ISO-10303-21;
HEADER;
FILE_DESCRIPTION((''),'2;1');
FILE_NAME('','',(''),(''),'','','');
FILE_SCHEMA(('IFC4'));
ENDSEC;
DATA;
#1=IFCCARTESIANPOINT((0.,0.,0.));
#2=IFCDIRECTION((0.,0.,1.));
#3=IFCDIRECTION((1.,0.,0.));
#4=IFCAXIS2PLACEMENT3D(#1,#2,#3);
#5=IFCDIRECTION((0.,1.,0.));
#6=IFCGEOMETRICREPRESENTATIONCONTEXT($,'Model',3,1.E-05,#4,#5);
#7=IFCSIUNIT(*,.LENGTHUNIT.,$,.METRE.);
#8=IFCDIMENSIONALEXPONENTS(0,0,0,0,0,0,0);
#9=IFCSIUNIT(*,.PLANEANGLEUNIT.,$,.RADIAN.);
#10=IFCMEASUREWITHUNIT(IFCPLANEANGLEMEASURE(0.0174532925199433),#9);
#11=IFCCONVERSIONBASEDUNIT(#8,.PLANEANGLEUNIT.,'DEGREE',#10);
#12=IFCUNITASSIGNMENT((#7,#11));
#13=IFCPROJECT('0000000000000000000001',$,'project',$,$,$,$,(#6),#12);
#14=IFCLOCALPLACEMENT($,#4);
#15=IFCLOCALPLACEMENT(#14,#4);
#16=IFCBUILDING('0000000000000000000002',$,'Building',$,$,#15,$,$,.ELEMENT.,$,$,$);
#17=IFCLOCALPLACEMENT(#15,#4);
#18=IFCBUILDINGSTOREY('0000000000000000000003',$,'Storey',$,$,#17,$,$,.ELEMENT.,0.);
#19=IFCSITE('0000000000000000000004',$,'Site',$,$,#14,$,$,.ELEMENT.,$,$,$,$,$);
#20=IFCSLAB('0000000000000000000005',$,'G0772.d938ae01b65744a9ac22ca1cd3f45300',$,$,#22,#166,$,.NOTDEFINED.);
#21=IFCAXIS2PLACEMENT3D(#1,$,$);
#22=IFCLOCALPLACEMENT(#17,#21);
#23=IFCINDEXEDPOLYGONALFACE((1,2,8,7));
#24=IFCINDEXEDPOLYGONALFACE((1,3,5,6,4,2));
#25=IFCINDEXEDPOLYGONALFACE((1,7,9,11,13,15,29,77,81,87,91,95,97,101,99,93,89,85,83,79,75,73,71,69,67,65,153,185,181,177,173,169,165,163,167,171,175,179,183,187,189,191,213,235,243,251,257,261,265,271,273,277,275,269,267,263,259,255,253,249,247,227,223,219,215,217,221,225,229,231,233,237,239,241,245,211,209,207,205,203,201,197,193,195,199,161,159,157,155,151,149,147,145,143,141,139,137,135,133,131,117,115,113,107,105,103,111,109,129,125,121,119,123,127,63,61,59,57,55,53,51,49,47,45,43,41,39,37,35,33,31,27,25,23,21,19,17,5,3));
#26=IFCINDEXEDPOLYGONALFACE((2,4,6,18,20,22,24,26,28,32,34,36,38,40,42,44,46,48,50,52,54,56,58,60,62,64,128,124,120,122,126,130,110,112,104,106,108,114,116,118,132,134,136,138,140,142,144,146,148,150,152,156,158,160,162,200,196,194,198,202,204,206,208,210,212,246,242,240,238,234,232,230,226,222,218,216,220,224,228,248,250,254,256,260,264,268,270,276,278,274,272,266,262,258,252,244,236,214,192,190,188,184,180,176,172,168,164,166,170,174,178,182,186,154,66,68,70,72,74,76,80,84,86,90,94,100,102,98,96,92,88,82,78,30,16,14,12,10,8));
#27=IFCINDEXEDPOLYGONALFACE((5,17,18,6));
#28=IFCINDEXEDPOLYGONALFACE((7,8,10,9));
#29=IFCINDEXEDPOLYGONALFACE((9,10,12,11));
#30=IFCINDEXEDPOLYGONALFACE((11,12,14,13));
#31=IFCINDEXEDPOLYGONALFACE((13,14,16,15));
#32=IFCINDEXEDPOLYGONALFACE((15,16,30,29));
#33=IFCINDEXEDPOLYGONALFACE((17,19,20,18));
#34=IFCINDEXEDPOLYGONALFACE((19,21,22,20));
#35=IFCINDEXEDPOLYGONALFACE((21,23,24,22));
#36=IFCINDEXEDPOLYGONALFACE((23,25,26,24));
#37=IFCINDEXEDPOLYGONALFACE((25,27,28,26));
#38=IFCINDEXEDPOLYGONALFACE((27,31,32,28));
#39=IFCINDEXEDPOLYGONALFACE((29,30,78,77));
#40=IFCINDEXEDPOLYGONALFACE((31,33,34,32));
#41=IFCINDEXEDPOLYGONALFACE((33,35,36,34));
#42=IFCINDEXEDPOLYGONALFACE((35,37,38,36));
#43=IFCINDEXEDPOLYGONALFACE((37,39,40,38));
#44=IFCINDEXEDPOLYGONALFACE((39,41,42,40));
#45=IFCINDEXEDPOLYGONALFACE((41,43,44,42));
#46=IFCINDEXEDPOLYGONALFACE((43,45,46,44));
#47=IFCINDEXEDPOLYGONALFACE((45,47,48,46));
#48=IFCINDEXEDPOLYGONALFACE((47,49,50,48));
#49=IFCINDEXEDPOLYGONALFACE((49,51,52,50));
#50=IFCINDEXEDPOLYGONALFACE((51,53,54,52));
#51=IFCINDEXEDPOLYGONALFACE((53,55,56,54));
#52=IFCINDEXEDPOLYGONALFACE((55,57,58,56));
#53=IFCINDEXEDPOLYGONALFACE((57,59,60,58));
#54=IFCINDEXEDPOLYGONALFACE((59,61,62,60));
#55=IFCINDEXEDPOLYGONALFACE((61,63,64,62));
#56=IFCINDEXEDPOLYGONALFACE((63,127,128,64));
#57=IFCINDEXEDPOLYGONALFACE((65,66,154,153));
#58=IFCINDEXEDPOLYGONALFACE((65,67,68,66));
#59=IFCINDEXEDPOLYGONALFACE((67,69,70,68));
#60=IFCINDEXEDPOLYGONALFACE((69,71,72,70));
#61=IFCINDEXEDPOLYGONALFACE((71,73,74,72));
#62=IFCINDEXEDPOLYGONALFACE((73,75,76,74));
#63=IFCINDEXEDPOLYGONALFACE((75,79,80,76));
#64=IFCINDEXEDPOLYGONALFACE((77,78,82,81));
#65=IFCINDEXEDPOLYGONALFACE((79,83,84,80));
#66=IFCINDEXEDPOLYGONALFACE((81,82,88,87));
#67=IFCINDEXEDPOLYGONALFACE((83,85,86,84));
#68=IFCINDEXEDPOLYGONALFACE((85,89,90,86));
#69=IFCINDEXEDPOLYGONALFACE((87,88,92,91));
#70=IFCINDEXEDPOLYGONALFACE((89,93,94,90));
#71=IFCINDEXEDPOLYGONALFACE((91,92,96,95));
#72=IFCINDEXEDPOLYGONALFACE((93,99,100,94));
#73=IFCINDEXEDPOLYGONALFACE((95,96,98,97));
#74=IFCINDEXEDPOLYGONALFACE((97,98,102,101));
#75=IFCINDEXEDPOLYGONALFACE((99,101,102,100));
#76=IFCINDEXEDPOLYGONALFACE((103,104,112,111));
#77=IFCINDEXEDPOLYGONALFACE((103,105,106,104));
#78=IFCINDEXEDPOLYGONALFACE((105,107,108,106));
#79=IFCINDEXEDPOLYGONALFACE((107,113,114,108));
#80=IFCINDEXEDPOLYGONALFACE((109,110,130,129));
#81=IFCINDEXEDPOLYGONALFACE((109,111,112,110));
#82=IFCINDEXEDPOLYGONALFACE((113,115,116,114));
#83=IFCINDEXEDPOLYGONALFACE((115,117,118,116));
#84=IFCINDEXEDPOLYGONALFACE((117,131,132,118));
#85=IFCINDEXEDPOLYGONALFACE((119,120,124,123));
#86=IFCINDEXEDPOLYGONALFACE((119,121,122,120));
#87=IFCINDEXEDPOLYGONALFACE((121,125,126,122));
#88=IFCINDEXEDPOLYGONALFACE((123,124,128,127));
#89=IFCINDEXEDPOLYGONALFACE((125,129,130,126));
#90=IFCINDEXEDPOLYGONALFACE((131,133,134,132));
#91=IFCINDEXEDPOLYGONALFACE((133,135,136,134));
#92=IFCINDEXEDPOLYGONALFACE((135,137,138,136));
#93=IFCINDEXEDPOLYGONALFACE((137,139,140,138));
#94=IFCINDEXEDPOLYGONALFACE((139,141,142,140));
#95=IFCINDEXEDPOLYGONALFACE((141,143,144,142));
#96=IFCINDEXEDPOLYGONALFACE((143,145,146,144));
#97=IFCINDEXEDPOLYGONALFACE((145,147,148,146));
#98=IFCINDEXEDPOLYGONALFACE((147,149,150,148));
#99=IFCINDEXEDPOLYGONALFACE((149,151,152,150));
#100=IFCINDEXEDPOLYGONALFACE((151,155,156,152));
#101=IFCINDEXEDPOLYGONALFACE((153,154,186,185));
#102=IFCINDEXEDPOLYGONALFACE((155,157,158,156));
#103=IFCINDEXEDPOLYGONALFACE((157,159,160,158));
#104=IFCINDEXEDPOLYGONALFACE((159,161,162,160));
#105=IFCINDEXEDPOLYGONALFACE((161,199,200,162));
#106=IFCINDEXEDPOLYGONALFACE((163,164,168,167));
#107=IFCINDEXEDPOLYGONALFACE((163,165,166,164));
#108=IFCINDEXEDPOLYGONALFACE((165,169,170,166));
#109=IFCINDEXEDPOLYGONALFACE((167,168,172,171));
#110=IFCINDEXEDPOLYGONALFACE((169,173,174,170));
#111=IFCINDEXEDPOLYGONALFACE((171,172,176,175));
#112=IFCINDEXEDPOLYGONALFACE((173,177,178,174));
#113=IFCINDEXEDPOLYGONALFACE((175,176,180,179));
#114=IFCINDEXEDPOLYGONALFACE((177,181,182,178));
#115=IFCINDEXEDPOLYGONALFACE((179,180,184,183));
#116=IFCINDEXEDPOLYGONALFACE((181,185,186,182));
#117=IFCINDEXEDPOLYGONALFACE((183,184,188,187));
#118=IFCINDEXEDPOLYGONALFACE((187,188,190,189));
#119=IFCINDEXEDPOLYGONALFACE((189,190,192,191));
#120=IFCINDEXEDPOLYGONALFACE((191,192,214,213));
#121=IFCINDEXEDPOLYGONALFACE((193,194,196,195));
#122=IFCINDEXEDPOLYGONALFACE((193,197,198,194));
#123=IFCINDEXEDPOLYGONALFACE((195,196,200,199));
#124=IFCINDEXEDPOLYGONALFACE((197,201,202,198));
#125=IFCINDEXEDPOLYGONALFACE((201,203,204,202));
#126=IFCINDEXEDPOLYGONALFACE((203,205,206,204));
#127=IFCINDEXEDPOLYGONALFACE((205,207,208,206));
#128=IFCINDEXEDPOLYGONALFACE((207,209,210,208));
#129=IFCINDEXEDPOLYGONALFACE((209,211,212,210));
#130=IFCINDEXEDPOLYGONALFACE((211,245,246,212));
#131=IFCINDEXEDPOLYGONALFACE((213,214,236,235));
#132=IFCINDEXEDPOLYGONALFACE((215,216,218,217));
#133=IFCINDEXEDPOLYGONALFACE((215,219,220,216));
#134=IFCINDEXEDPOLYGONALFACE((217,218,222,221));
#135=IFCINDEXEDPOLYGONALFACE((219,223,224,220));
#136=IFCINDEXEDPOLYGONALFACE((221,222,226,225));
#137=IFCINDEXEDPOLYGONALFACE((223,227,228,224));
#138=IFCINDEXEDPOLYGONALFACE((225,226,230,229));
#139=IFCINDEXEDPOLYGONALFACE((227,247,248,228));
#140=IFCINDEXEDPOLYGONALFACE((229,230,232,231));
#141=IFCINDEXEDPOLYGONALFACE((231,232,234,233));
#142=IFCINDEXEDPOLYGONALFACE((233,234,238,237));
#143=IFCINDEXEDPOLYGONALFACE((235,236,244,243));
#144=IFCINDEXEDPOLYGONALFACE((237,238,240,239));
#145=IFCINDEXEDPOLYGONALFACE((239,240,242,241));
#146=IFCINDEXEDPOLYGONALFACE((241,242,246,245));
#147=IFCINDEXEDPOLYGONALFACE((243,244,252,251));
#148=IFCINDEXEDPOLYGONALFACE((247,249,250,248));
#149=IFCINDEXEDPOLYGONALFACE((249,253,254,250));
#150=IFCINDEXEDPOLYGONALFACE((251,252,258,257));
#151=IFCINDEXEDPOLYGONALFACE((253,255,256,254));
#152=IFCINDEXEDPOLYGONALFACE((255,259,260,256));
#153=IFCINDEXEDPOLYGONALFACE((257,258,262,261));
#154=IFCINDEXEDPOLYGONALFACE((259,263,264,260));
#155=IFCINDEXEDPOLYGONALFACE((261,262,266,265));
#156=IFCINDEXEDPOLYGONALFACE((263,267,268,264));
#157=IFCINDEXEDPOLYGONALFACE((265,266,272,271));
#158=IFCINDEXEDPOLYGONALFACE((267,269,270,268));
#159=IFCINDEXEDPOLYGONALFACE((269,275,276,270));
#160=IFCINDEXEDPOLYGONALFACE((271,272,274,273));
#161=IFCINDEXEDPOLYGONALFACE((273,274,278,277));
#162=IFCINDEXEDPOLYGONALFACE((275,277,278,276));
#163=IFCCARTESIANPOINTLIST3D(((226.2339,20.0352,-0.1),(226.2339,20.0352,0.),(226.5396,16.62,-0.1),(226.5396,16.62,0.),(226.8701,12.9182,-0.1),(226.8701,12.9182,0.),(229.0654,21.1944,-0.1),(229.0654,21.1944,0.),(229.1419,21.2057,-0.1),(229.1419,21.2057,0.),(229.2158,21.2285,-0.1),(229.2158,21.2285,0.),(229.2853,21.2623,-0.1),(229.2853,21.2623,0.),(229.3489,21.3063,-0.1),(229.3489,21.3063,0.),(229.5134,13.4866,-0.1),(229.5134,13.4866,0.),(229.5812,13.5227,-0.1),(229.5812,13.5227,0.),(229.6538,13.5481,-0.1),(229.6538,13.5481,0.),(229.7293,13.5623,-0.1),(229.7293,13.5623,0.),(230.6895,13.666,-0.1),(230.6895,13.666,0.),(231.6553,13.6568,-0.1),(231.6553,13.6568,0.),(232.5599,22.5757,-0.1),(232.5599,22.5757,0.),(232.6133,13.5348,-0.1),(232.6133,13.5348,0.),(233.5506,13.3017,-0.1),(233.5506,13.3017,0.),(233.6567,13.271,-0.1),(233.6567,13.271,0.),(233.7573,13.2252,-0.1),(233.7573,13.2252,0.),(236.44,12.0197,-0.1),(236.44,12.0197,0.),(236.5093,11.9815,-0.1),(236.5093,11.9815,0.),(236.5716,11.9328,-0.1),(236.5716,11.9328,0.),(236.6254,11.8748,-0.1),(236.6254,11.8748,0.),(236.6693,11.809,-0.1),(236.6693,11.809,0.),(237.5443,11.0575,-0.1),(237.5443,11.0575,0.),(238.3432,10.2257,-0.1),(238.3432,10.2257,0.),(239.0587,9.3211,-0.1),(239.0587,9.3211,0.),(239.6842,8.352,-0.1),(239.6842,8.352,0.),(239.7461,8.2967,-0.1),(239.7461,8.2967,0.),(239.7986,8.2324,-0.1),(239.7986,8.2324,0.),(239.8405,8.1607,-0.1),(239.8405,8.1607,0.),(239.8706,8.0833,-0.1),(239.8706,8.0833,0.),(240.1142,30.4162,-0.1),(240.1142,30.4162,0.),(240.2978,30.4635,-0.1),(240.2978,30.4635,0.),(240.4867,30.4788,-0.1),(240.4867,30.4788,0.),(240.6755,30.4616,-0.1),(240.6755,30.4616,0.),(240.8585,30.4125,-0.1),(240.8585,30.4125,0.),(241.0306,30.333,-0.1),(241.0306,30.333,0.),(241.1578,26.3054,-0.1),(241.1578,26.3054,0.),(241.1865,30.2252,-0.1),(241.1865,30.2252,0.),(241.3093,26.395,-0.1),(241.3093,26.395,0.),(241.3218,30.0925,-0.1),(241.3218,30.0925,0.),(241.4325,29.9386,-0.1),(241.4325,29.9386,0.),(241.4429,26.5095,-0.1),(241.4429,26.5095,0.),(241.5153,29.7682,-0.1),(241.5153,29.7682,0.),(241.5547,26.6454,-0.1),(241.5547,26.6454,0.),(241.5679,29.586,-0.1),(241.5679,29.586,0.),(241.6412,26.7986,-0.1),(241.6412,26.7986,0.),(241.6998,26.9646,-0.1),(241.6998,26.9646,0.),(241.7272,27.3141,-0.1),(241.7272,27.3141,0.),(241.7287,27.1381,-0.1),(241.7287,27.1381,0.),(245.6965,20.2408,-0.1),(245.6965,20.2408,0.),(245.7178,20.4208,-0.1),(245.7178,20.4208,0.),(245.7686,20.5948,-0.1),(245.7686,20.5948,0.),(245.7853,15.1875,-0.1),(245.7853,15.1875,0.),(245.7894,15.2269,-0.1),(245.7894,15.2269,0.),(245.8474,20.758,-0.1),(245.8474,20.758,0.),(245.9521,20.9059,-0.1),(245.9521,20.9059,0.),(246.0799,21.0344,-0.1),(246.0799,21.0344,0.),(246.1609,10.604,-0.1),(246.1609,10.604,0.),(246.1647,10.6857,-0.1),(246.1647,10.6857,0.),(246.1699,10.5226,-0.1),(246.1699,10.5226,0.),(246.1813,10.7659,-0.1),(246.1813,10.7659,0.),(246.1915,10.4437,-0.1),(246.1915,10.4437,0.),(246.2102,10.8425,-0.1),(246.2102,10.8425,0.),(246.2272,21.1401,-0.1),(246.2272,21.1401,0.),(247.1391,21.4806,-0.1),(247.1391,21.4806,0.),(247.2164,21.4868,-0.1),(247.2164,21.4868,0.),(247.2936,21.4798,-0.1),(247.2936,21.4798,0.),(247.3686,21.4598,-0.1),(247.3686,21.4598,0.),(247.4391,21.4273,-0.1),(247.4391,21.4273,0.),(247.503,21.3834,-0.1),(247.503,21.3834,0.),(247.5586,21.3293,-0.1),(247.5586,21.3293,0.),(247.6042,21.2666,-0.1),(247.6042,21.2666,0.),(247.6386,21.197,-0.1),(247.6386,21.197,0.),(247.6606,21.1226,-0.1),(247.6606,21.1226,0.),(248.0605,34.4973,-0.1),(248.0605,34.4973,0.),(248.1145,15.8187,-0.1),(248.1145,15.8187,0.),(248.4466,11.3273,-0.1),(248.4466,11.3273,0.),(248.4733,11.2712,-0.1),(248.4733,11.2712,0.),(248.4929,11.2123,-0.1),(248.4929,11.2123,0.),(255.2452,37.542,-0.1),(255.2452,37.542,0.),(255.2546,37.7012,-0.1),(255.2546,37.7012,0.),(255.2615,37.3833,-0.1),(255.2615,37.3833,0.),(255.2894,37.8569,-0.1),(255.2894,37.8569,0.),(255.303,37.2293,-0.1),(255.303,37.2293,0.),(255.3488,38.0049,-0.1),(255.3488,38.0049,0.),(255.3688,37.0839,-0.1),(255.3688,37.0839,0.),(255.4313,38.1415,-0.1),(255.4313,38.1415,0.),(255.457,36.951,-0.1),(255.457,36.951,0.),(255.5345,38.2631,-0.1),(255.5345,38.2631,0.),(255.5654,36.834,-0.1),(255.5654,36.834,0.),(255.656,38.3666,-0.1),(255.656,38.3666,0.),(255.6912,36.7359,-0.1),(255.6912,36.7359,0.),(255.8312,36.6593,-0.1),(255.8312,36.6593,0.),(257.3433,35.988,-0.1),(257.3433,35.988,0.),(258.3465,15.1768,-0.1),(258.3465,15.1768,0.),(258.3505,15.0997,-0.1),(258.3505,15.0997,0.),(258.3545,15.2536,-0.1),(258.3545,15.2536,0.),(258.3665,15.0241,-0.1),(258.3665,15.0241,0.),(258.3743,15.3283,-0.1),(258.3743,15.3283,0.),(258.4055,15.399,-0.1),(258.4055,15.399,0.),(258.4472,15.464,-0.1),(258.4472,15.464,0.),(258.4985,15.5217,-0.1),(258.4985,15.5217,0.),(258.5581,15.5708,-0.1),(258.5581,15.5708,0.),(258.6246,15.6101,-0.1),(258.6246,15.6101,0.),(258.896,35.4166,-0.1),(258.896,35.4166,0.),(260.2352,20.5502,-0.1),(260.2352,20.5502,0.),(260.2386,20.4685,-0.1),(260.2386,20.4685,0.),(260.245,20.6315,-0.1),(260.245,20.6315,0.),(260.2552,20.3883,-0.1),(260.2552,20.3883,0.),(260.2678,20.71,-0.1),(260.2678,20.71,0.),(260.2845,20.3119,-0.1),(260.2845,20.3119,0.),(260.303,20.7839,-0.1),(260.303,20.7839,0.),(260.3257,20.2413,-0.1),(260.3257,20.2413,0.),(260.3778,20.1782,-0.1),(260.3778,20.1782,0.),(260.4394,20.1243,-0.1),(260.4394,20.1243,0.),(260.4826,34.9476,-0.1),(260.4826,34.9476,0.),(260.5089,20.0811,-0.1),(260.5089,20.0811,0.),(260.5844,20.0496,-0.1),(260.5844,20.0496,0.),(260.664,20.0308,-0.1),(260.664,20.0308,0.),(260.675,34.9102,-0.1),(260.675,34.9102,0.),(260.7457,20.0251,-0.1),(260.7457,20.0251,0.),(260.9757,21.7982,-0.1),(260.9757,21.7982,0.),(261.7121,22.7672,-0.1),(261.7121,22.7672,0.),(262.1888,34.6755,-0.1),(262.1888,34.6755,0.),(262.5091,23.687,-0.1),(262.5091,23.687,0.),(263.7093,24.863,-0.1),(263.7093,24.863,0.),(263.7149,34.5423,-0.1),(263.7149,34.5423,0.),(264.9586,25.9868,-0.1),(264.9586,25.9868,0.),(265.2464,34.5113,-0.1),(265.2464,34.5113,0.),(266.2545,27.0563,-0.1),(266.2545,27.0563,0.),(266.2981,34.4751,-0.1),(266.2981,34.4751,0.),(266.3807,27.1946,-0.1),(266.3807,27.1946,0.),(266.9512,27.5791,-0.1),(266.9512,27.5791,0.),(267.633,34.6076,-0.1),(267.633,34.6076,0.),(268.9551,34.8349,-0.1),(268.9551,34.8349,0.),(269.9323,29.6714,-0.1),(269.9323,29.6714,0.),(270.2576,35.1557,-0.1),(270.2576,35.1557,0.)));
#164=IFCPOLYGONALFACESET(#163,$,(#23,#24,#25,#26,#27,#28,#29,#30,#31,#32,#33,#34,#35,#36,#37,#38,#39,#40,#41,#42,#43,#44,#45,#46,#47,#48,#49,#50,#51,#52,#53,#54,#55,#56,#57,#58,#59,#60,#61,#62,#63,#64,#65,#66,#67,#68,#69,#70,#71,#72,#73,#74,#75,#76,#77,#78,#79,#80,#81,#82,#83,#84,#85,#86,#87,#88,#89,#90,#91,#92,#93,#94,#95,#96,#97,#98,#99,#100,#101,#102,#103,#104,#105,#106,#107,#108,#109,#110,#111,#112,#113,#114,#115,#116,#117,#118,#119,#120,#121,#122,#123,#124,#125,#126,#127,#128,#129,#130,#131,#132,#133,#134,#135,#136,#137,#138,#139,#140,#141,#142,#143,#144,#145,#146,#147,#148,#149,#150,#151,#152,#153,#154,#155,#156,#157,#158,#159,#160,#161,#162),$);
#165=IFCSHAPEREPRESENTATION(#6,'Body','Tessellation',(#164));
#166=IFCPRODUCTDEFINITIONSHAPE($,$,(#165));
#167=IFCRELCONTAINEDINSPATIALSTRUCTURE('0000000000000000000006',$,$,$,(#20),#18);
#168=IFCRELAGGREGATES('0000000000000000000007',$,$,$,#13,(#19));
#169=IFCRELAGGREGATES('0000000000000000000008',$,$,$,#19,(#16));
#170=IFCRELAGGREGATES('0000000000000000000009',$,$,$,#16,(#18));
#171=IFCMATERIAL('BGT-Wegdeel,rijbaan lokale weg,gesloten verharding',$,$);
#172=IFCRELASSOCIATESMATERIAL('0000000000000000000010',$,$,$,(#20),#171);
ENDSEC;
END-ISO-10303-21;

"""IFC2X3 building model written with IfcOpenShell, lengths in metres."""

from ifc_helpers import new_model, entity, si_unit, converted_unit, direction, frame, origin_with_axes, place, context, project, spatial, polyline, outline, extrude, material, element, save


model = new_model("IFC2X3")

# Units and contexts
model_context = context("Model", 3, precision=1e-05, world=origin_with_axes(), true_north=direction((0.0, 1.0, 0.0)))
ifc_project = project(units=[si_unit("LENGTHUNIT", "METRE"), converted_unit("PLANEANGLEUNIT", "DEGREE", entity("IfcPlaneAngleMeasure", 0.0174532925199433), si_unit("PLANEANGLEUNIT", "RADIAN"), dimensions=[0, 0, 0, 0, 0, 0, 0])], contexts=[model_context])

# Site, building, storey
site_placement = place(None, origin_with_axes())
site = spatial("IfcSite", under=ifc_project, at=site_placement, Name="Site", CompositionType="ELEMENT")
building_placement = place(site_placement, origin_with_axes())
building = spatial("IfcBuilding", under=site, at=building_placement, Name="Building", CompositionType="ELEMENT")
storey_placement = place(building_placement, origin_with_axes())
storey = spatial("IfcBuildingStorey", under=building, at=storey_placement, Name="Storey", CompositionType="ELEMENT", Elevation=0.0)

# Slab
ifc_material_1 = material(Name="BGT-Wegdeel,rijbaan lokale weg,gesloten verharding")
slab_1_placement = place(storey_placement, frame((0.0, 0.0, -0.1), z_axis=(0.0, 0.0, 1.0), x_axis=(1.0, 0.0, 0.0)))
element("IfcSlab", 1, at=slab_1_placement, inside=storey, material=ifc_material_1, Name="G0772.d938ae01b65744a9ac22ca1cd3f45300", PredefinedType="NOTDEFINED", context=model_context, shape_type="SweptSolid", body=[
    extrude(outline(polyline([(257.3433, 35.988), (258.896, 35.4166), (260.4826, 34.9476), (260.675, 34.9102), (262.1888, 34.6755), (263.7149, 34.5423), (265.2464, 34.5113), (266.2981, 34.4751), (267.633, 34.6076), (268.9551, 34.8349), (270.2576, 35.1557), (269.9323, 29.6714), (266.9512, 27.5791), (266.3807, 27.1946), (266.2545, 27.0563), (264.9586, 25.9868), (263.7093, 24.863), (262.5091, 23.687), (261.7121, 22.7672), (260.9757, 21.7982), (260.303, 20.7839), (260.2678, 20.71), (260.245, 20.6315), (260.2352, 20.5502), (260.2386, 20.4685), (260.2552, 20.3883), (260.2845, 20.3119), (260.3257, 20.2413), (260.3778, 20.1782), (260.4394, 20.1243), (260.5089, 20.0811), (260.5844, 20.0496), (260.664, 20.0308), (260.7457, 20.0251), (258.6246, 15.6101), (258.5581, 15.5708), (258.4985, 15.5217), (258.4472, 15.464), (258.4055, 15.399), (258.3743, 15.3283), (258.3545, 15.2536), (258.3465, 15.1768), (258.3505, 15.0997), (258.3665, 15.0241), (248.4929, 11.2123), (248.4733, 11.2712), (248.4466, 11.3273), (248.1145, 15.8187), (247.6606, 21.1226), (247.6386, 21.197), (247.6042, 21.2666), (247.5586, 21.3293), (247.503, 21.3834), (247.4391, 21.4273), (247.3686, 21.4598), (247.2936, 21.4798), (247.2164, 21.4868), (247.1391, 21.4806), (246.2272, 21.1401), (246.0799, 21.0344), (245.9521, 20.9059), (245.8474, 20.758), (245.7686, 20.5948), (245.7178, 20.4208), (245.6965, 20.2408), (245.7894, 15.2269), (245.7853, 15.1875), (246.2102, 10.8425), (246.1813, 10.7659), (246.1647, 10.6857), (246.1609, 10.604), (246.1699, 10.5226), (246.1915, 10.4437), (239.8706, 8.0833), (239.8405, 8.1607), (239.7986, 8.2324), (239.7461, 8.2967), (239.6842, 8.352), (239.0587, 9.3211), (238.3432, 10.2257), (237.5443, 11.0575), (236.6693, 11.809), (236.6254, 11.8748), (236.5716, 11.9328), (236.5093, 11.9815), (236.44, 12.0197), (233.7573, 13.2252), (233.6567, 13.271), (233.5506, 13.3017), (232.6133, 13.5348), (231.6553, 13.6568), (230.6895, 13.666), (229.7293, 13.5623), (229.6538, 13.5481), (229.5812, 13.5227), (229.5134, 13.4866), (226.8701, 12.9182), (226.5396, 16.62), (226.2339, 20.0352), (229.0654, 21.1944), (229.1419, 21.2057), (229.2158, 21.2285), (229.2853, 21.2623), (229.3489, 21.3063), (232.5599, 22.5757), (241.1578, 26.3054), (241.3093, 26.395), (241.4429, 26.5095), (241.5547, 26.6454), (241.6412, 26.7986), (241.6998, 26.9646), (241.7287, 27.1381), (241.7272, 27.3141), (241.5679, 29.586), (241.5153, 29.7682), (241.4325, 29.9386), (241.3218, 30.0925), (241.1865, 30.2252), (241.0306, 30.333), (240.8585, 30.4125), (240.6755, 30.4616), (240.4867, 30.4788), (240.2978, 30.4635), (240.1142, 30.4162), (248.0605, 34.4973), (255.656, 38.3666), (255.5345, 38.2631), (255.4313, 38.1415), (255.3488, 38.0049), (255.2894, 37.8569), (255.2546, 37.7012), (255.2452, 37.542), (255.2615, 37.3833), (255.303, 37.2293), (255.3688, 37.0839), (255.457, 36.951), (255.5654, 36.834), (255.6912, 36.7359), (255.8312, 36.6593), (257.3433, 35.988)])), origin_with_axes(), (0.0, 0.0, 1.0), 0.1),
])

save(model, "model.ifc")
